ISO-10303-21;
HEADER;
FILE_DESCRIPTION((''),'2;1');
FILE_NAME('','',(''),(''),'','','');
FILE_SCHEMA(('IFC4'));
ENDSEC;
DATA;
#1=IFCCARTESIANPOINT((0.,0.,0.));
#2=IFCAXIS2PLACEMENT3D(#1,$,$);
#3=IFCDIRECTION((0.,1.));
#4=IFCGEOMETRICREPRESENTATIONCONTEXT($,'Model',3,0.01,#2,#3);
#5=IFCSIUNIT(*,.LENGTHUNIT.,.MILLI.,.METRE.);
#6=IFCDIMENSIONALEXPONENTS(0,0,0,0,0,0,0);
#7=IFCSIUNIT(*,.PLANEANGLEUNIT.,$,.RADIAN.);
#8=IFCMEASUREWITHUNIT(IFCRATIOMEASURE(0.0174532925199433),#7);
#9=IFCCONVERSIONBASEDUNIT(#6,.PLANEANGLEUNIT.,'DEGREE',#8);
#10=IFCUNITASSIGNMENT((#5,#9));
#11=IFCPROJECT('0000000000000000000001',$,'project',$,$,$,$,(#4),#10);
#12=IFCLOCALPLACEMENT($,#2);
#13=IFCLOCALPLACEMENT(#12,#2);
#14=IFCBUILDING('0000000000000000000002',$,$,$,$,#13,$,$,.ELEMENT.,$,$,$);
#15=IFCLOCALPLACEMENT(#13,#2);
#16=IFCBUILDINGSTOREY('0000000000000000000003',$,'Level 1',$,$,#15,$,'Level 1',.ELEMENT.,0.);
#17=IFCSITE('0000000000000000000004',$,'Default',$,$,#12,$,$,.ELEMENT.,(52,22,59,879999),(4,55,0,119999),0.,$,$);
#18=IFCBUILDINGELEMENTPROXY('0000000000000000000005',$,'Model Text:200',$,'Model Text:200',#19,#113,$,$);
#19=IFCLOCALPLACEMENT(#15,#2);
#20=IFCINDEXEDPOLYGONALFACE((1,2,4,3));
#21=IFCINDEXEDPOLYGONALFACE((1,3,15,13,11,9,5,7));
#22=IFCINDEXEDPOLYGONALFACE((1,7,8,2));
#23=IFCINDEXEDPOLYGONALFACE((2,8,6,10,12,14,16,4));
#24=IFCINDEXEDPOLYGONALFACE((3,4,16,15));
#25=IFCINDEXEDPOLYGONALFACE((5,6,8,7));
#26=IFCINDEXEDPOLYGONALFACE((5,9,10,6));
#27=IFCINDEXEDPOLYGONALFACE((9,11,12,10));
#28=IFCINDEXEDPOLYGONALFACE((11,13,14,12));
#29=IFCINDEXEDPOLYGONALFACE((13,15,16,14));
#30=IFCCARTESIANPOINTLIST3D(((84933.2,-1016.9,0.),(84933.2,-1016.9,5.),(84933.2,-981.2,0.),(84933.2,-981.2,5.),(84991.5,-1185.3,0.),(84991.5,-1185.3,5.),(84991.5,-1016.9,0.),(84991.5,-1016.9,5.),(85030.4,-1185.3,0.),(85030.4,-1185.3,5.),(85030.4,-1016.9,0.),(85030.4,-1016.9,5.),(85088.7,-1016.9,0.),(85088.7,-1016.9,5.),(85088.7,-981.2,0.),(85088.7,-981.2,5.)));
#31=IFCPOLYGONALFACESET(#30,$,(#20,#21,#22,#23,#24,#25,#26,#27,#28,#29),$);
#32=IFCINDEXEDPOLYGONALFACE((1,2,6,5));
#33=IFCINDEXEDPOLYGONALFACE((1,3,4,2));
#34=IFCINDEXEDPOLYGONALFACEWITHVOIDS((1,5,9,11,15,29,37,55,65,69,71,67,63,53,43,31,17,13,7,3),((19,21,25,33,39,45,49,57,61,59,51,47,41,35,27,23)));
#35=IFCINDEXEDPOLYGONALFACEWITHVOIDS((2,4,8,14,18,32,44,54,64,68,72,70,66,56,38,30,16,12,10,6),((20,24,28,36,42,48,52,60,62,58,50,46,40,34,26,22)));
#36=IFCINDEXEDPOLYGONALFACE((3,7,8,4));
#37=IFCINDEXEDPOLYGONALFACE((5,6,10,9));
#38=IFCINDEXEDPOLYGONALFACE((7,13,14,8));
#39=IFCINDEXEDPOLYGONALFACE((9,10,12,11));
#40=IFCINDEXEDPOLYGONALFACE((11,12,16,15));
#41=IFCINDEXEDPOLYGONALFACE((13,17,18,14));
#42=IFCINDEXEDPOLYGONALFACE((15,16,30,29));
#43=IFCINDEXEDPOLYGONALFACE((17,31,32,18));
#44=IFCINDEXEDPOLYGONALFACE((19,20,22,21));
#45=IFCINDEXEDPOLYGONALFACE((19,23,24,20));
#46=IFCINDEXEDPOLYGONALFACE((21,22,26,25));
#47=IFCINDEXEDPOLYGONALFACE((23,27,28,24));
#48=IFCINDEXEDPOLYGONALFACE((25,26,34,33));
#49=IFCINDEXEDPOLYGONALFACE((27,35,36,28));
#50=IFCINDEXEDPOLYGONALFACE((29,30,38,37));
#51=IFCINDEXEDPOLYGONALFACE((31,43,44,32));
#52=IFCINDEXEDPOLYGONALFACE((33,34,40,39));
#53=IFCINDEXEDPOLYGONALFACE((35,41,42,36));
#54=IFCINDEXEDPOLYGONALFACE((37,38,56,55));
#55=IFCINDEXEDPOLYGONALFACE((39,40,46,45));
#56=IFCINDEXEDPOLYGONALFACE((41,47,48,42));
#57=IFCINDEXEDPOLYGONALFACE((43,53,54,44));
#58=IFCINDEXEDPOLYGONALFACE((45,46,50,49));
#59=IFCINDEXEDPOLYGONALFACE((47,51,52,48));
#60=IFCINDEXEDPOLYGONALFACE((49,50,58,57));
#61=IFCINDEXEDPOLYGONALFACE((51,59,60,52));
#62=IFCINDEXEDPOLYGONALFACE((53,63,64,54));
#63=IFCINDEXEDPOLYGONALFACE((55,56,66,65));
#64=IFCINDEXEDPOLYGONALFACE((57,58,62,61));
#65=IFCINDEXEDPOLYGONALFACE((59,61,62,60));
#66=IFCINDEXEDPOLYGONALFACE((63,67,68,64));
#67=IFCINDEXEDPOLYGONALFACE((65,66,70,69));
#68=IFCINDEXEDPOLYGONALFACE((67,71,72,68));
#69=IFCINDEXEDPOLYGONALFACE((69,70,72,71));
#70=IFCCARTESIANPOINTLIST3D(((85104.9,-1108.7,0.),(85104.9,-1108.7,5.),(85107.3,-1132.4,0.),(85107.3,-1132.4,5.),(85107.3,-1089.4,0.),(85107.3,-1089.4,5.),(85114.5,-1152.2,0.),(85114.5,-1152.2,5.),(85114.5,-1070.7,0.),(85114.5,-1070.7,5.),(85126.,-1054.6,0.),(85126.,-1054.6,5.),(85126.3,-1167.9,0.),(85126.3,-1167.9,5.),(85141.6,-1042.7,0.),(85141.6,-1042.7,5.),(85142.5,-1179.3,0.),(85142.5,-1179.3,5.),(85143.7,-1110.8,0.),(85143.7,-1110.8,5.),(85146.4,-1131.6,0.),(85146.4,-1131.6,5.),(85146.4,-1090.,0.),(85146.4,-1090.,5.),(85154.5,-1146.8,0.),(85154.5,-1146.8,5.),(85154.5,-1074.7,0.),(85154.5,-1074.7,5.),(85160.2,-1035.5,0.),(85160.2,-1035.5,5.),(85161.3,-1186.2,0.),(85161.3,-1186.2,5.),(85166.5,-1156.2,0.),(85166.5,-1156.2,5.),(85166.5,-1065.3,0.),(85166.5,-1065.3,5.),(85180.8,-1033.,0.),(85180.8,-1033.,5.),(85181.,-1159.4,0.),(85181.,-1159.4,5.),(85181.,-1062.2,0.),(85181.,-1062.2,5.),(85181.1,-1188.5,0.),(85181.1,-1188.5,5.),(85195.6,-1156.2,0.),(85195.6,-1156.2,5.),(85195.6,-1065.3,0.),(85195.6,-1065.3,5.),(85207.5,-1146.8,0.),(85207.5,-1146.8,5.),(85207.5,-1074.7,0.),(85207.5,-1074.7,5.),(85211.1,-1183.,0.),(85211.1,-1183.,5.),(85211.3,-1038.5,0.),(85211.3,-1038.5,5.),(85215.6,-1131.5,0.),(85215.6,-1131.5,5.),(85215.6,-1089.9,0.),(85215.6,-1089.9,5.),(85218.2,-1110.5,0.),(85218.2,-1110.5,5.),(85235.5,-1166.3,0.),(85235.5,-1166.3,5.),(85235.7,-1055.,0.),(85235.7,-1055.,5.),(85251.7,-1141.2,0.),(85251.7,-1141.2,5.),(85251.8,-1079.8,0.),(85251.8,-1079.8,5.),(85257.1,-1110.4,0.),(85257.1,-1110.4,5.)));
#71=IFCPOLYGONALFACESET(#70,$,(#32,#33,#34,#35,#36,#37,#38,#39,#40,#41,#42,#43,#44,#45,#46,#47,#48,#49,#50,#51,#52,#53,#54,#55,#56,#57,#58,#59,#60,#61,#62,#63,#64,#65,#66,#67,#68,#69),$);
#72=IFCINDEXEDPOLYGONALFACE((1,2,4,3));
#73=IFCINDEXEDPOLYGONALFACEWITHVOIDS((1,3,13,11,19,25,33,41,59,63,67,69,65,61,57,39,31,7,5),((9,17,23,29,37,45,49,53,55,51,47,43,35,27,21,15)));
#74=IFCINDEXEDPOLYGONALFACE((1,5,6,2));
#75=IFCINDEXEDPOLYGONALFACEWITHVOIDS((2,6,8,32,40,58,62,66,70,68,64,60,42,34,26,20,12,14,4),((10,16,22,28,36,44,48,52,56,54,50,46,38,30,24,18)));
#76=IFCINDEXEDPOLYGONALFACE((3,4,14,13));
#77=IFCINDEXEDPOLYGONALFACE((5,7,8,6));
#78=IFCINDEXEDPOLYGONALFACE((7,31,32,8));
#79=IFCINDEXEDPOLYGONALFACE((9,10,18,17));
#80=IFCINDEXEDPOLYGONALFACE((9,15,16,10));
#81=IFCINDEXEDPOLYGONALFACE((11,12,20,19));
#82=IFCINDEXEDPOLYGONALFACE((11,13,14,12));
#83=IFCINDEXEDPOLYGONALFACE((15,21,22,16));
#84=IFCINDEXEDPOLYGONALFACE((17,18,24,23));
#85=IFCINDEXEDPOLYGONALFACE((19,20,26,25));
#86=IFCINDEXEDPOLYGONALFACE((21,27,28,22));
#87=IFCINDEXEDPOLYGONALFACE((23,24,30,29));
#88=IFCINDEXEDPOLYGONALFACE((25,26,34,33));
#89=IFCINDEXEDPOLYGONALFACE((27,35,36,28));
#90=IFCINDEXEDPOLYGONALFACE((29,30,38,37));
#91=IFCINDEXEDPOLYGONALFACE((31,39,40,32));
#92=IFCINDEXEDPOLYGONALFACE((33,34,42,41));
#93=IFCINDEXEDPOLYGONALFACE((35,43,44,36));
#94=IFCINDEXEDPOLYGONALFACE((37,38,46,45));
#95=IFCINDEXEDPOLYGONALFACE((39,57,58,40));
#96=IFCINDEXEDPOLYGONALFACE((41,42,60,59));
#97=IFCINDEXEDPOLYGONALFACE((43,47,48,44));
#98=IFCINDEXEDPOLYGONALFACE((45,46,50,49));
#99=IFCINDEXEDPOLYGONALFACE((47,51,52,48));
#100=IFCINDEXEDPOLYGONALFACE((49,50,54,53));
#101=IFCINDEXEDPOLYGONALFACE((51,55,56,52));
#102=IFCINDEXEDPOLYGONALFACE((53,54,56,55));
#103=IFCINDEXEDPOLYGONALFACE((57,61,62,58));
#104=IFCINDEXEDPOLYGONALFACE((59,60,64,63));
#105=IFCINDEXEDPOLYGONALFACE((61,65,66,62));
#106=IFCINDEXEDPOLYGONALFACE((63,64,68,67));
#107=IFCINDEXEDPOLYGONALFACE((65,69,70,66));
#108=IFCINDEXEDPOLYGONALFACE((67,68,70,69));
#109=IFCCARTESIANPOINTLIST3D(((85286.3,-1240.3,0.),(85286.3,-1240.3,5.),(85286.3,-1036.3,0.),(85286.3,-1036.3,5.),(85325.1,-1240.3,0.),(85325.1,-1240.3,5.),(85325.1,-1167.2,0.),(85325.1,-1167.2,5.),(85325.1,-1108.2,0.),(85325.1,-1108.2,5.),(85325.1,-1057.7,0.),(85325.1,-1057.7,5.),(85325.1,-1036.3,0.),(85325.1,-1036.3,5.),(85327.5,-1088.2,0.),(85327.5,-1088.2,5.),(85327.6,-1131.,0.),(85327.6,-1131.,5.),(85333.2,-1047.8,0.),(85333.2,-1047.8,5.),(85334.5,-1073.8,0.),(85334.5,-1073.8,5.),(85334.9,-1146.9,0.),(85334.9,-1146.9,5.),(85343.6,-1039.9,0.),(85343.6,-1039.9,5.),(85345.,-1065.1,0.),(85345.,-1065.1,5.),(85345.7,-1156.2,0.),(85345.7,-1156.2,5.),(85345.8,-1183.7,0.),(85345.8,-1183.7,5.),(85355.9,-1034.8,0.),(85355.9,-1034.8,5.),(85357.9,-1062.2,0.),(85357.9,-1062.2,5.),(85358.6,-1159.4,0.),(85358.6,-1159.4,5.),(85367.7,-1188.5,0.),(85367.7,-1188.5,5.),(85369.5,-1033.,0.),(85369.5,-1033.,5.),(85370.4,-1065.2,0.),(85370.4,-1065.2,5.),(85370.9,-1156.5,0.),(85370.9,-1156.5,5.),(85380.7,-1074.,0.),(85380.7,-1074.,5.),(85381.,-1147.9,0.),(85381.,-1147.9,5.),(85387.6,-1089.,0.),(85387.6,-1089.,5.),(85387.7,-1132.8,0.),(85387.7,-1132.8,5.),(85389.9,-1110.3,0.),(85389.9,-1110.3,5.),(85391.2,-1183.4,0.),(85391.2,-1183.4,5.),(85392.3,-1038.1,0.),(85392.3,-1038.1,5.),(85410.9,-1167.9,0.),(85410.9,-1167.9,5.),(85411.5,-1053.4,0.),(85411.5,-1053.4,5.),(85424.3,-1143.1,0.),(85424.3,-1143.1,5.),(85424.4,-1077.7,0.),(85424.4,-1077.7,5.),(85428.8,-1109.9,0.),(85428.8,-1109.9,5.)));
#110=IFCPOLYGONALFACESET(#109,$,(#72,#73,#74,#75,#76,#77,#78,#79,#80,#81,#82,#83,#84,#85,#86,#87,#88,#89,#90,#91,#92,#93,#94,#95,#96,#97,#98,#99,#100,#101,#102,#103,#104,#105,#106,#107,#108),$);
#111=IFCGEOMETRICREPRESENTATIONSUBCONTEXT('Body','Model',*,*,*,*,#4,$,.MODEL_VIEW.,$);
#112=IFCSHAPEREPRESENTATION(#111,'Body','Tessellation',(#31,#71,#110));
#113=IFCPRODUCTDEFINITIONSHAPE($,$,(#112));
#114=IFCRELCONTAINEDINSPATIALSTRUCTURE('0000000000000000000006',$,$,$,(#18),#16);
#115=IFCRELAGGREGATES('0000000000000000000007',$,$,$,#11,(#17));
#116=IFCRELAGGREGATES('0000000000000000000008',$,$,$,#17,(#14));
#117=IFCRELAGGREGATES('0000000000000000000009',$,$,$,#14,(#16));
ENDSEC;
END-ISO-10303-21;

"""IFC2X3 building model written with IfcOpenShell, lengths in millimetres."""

from ifc_helpers import new_model, entity, si_unit, converted_unit, direction, frame, origin, place, context, subcontext, project, spatial, polyline, outline, extrude, element, save


model = new_model("IFC2X3")

# Units and contexts
model_context = context("Model", 3, precision=0.01, world=origin(), true_north=direction((0.0, 1.0)))
body_context = subcontext(model_context, "Body", "Model", "MODEL_VIEW")
ifc_project = project(units=[si_unit("LENGTHUNIT", "METRE", prefix="MILLI"), converted_unit("PLANEANGLEUNIT", "DEGREE", entity("IfcRatioMeasure", 0.0174532925199433), si_unit("PLANEANGLEUNIT", "RADIAN"), dimensions=[0, 0, 0, 0, 0, 0, 0])], contexts=[model_context])

# Site, building, storey
site_placement = place(None, origin())
site = spatial("IfcSite", under=ifc_project, at=site_placement, Name="Default", CompositionType="ELEMENT", RefLatitude=(52, 22, 59, 879999), RefLongitude=(4, 55, 0, 119999), RefElevation=0.0)
building_placement = place(site_placement, origin())
building = spatial("IfcBuilding", under=site, at=building_placement, CompositionType="ELEMENT")
storey_placement = place(building_placement, origin())
storey = spatial("IfcBuildingStorey", under=building, at=storey_placement, Name="Level 1", LongName="Level 1", CompositionType="ELEMENT", Elevation=0.0)

# Building element proxy
proxy_1_placement = place(building_placement, origin())
element("IfcBuildingElementProxy", 1, at=proxy_1_placement, inside=storey, Name="Model Text:200", ObjectType="Model Text:200", context=body_context, shape_type="SweptSolid", body=[
    extrude(outline(polyline([(-19.4, -135.2), (19.4, -135.2), (19.4, 33.2), (77.7, 33.2), (77.7, 68.8), (-77.7, 68.8), (-77.7, 33.2), (-19.4, 33.2), (-19.4, -135.2)])), frame((85010.9, -1050.1, 0.0)), (0.0, 0.0, 1.0), 5.0),
    extrude(outline(polyline([(-8.8, -65.7), (15.1, -65.7), (35.5, -60.5), (52.3, -50.4), (65.3, -35.4), (74.1, -17.3), (78.4, 2.1), (75.9, 32.5), (61.8, 58.5), (38.4, 77.1), (8.3, 85.6), (-22.7, 83.3), (-49.0, 69.9), (-67.8, 47.3), (-76.3, 17.5), (-76.0, -3.3), (-70.7, -22.5), (-60.5, -39.2), (-45.5, -52.3), (-27.7, -61.4), (-8.8, -65.7)]), holes=[polyline([(-2.7, -27.2), (-23.1, -22.5), (-37.5, -12.9), (-45.7, 0.0), (-47.3, 14.8), (-42.7, 28.9), (-32.2, 39.9), (-16.3, 46.3), (4.5, 46.9), (25.1, 42.1), (39.6, 32.6), (47.7, 19.7), (49.4, 5.0), (44.8, -9.2), (34.2, -20.2), (18.2, -26.7), (-2.7, -27.2)])]), frame((85171.1, -1110.8, 0.0), z_axis=(0.0, 0.0, 1.0), x_axis=(0.100608, -0.994926, 0.0)), (0.0, 0.0, 1.0), 5.0),
    extrude(outline(polyline([(-73.1, -75.4), (130.9, -75.4), (130.9, -36.6), (57.8, -36.6), (74.3, -15.9), (79.1, 6.0), (73.9, 29.5), (58.4, 49.2), (33.6, 62.6), (0.5, 67.1), (-31.8, 62.8), (-56.1, 49.8), (-71.3, 30.7), (-76.4, 7.8), (-74.7, -5.8), (-69.6, -18.1), (-61.7, -28.5), (-51.7, -36.6), (-73.1, -36.6), (-73.1, -75.4)]), holes=[polyline([(-1.2, -36.6), (-21.2, -34.2), (-35.6, -27.2), (-44.3, -16.7), (-47.2, -3.8), (-44.3, 8.7), (-35.4, 19.0), (-20.4, 25.9), (0.8, 28.2), (23.3, 26.0), (38.5, 19.3), (47.1, 9.2), (49.9, -3.1), (46.8, -16.0), (37.4, -26.8), (21.5, -34.1), (-1.2, -36.6)])]), frame((85361.7, -1109.4, 0.0), z_axis=(0.0, 0.0, 1.0), x_axis=(0.0, -1.0, 0.0)), (0.0, 0.0, 1.0), 5.0),
])

save(model, "model.ifc")
